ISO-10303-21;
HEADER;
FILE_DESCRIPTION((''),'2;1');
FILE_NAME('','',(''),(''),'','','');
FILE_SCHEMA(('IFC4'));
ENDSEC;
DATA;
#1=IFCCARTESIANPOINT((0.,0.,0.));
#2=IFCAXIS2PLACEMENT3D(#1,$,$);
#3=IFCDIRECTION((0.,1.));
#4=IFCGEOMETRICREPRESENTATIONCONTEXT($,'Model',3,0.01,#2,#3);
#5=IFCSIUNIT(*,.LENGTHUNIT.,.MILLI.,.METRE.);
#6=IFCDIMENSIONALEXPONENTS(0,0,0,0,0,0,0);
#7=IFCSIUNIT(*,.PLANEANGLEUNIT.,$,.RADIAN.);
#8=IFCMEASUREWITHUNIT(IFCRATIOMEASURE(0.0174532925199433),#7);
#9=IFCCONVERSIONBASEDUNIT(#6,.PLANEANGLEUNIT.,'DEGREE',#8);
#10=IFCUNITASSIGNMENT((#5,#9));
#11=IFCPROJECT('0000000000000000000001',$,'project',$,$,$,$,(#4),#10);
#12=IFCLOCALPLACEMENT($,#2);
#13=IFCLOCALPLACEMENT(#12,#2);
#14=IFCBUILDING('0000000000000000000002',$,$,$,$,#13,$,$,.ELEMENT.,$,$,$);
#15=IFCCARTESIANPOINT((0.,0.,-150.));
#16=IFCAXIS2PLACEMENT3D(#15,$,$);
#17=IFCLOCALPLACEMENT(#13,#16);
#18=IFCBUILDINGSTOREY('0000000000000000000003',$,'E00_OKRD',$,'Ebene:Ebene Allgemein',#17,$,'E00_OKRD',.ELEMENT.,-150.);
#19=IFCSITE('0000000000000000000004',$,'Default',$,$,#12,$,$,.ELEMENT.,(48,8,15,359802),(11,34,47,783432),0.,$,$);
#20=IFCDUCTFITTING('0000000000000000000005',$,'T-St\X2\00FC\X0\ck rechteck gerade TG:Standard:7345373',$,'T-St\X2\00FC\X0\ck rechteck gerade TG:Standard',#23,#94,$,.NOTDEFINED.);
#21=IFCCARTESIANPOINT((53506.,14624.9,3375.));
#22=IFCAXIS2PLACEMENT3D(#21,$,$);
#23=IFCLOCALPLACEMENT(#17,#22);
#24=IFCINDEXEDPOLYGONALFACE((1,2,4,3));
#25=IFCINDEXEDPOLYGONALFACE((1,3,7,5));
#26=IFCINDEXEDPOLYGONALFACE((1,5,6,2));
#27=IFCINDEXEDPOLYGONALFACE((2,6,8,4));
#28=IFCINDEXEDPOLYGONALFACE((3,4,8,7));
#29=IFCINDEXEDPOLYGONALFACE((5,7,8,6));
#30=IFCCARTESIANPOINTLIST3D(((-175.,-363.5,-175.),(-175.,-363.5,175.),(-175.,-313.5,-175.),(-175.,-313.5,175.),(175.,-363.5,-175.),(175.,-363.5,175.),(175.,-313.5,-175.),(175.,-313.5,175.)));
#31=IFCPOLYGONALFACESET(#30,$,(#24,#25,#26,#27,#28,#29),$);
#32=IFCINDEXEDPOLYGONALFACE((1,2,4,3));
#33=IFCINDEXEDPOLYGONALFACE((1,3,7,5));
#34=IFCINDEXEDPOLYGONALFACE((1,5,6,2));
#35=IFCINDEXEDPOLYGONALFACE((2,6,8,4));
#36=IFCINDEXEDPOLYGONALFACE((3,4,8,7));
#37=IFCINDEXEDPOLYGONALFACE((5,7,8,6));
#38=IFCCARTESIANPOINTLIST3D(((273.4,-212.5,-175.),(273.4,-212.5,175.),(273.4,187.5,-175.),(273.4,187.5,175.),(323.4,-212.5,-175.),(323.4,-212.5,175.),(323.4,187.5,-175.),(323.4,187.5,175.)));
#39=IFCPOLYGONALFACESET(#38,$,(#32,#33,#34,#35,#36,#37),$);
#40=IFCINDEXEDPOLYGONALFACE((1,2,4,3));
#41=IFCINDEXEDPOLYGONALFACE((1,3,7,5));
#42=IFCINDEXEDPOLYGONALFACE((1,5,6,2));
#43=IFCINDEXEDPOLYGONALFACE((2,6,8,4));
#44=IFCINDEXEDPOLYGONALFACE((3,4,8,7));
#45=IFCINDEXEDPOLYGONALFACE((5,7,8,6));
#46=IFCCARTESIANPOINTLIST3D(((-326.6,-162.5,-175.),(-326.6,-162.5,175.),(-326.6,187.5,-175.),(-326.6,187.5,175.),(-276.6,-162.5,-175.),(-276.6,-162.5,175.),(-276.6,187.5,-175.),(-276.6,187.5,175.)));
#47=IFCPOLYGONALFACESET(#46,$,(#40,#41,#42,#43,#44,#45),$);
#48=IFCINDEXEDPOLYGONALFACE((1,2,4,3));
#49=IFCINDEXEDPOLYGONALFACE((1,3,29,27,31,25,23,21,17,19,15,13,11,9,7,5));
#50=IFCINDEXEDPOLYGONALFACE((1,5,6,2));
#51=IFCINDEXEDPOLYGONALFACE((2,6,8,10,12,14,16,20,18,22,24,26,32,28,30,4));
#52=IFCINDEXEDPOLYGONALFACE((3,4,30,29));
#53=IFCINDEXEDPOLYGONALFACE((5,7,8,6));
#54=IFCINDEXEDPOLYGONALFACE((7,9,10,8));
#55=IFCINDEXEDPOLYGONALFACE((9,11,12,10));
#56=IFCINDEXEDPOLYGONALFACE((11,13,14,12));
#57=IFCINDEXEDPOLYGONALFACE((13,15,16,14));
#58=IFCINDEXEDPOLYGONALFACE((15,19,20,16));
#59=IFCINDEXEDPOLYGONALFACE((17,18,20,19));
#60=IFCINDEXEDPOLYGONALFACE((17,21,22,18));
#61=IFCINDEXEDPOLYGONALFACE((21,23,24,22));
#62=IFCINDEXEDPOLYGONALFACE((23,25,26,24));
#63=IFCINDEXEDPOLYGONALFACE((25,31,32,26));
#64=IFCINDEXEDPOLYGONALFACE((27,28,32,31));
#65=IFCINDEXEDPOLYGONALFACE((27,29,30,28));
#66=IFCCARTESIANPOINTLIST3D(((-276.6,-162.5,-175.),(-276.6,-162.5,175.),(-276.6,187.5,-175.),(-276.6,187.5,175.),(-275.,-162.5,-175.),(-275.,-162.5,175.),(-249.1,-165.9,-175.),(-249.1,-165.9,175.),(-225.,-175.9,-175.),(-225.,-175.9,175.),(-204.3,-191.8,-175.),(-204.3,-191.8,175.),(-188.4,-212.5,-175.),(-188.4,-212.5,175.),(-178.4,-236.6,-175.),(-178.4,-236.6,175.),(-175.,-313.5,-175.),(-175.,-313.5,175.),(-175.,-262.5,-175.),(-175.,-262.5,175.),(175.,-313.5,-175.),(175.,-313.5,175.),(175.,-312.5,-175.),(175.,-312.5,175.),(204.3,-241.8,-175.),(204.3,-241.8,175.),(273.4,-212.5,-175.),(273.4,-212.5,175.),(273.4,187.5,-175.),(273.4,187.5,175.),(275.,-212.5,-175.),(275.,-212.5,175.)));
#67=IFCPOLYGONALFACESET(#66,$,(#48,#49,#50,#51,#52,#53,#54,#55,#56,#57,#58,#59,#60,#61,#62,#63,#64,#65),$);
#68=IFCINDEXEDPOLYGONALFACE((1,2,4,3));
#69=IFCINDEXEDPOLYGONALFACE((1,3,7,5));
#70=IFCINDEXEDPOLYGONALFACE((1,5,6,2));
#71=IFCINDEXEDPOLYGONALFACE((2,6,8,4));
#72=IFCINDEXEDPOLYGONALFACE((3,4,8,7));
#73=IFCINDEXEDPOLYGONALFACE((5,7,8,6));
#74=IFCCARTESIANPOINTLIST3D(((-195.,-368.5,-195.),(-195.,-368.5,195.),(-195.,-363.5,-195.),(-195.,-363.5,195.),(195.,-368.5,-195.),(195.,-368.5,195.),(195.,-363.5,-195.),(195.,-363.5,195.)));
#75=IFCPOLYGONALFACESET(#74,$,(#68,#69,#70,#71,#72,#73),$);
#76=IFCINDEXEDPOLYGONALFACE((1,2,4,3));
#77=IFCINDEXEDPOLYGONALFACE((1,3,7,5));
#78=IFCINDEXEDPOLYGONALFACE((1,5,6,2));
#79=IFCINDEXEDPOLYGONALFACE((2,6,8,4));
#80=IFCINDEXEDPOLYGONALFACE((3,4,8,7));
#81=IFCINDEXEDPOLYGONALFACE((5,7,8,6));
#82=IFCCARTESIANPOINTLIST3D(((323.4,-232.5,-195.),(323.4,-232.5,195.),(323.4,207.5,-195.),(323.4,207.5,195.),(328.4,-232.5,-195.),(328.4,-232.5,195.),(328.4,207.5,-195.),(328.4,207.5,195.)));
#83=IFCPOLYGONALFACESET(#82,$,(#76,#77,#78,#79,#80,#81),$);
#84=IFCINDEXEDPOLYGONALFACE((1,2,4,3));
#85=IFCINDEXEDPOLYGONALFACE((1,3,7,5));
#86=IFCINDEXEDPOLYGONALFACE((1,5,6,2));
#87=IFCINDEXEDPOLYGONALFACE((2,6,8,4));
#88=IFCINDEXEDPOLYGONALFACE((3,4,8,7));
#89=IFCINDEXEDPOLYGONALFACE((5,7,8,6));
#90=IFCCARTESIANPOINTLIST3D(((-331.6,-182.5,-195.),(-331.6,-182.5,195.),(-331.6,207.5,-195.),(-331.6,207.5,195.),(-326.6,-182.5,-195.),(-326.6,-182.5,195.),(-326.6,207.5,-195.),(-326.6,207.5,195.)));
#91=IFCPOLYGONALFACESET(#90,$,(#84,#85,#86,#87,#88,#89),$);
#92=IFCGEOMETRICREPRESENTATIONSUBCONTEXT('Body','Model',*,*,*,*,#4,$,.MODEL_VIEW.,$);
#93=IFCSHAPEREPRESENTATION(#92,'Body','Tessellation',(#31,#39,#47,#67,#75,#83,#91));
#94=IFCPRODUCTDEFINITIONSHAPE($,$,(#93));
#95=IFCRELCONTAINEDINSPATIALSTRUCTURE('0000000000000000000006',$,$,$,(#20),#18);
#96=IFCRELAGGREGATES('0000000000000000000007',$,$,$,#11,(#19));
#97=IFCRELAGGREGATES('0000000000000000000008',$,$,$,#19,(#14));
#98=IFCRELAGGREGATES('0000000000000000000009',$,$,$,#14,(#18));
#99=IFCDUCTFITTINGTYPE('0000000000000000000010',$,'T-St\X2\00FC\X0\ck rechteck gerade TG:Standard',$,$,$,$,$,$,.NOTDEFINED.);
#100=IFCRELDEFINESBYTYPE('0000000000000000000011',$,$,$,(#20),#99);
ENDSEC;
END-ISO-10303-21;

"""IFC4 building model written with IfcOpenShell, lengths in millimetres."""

from ifc_helpers import new_model, entity, si_unit, converted_unit, direction, frame, frame_2d, origin, origin_2d_with_axis, place, context, subcontext, project, spatial, polyline, circle_curve, parameter, trimmed, segment, composite_curve, rectangle, outline, extrude, source, transform, mapped, type_object, type_shapes, element, save


model = new_model("IFC4")

# Units and contexts
model_context = context("Model", 3, precision=0.01, world=origin(), true_north=direction((0.0, 1.0)))
body_context = subcontext(model_context, "Body", "Model", "MODEL_VIEW")
ifc_project = project(units=[si_unit("LENGTHUNIT", "METRE", prefix="MILLI"), converted_unit("PLANEANGLEUNIT", "DEGREE", entity("IfcRatioMeasure", 0.0174532925199433), si_unit("PLANEANGLEUNIT", "RADIAN"), dimensions=[0, 0, 0, 0, 0, 0, 0])], contexts=[model_context])

# Site, building, storey
site_placement = place(None, origin())
site = spatial("IfcSite", under=ifc_project, at=site_placement, Name="Default", CompositionType="ELEMENT", RefLatitude=(48, 8, 15, 359802), RefLongitude=(11, 34, 47, 783432), RefElevation=0.0)
building_placement = place(site_placement, origin())
building = spatial("IfcBuilding", under=site, at=building_placement, CompositionType="ELEMENT")
storey_placement = place(building_placement, frame((0.0, 0.0, -150.0)))
storey = spatial("IfcBuildingStorey", under=building, at=storey_placement, Name="E00_OKRD", ObjectType="Ebene:Ebene Allgemein", LongName="E00_OKRD", CompositionType="ELEMENT", Elevation=-150.0)

# Duct fitting
duct_fitting_type_1 = type_object("IfcDuctFittingType", Name="T-Stück rechteck gerade TG:Standard", PredefinedType="NOTDEFINED")
shared_shape_1 = source(origin(), body_context, "Body", "SweptSolid", [
    extrude(rectangle(XDim=50.0, YDim=350.0, at=origin_2d_with_axis()), frame((0.0, -338.5, -175.0), z_axis=(0.0, 0.0, 1.0), x_axis=(0.0, -1.0, 0.0)), (0.0, 0.0, 1.0), 350.0),
    extrude(rectangle(XDim=50.0, YDim=400.0, at=origin_2d_with_axis()), frame((298.4, -12.5, -175.0), z_axis=(0.0, 0.0, 1.0), x_axis=(-1.0, 0.0, 0.0)), (0.0, 0.0, 1.0), 350.0),
    extrude(rectangle(XDim=50.0, YDim=350.0, at=origin_2d_with_axis()), frame((-301.6, 12.5, -175.0)), (0.0, 0.0, 1.0), 350.0),
    extrude(outline(composite_curve([segment(trimmed(circle_curve(frame_2d((-275.6, -154.8), x_axis=(-1.0, 0.0)), 100.0), [parameter(180.0)], [parameter(270.0)], True, "PARAMETER"), False, "CONTINUOUS"), segment(polyline([(-175.6, -154.8), (-175.6, -155.8)]), True, "CONTINUOUS"), segment(polyline([(-175.6, -155.8), (174.4, -155.8)]), True, "CONTINUOUS"), segment(polyline([(174.4, -155.8), (174.4, -104.8)]), True, "CONTINUOUS"), segment(trimmed(circle_curve(frame_2d((274.4, -104.8), x_axis=(-1.0, 0.0)), 100.0), [parameter(270.0)], [parameter(0.0)], True, "PARAMETER"), False, "CONTINUOUS"), segment(polyline([(274.4, -4.8), (276.0, -4.8)]), True, "CONTINUOUS"), segment(polyline([(276.0, -4.8), (276.0, 345.2)]), True, "CONTINUOUS"), segment(polyline([(276.0, 345.2), (-274.0, 345.2)]), True, "CONTINUOUS"), segment(polyline([(-274.0, 345.2), (-274.0, -54.8)]), True, "CONTINUOUS"), segment(polyline([(-274.0, -54.8), (-275.6, -54.8)]), True, "CONTINUOUS")], self_intersect=False)), frame((-0.6, -157.7, -175.0), z_axis=(0.0, 0.0, -1.0), x_axis=(-1.0, 0.0, 0.0)), (0.0, 0.0, -1.0), 350.0),
    extrude(rectangle(XDim=5.0, YDim=390.0, at=origin_2d_with_axis()), frame((0.0, -366.0, -195.0), z_axis=(0.0, 0.0, 1.0), x_axis=(0.0, 1.0, 0.0)), (0.0, 0.0, 1.0), 390.0),
    extrude(rectangle(XDim=5.0, YDim=440.0, at=origin_2d_with_axis()), frame((325.9, -12.5, -195.0), z_axis=(0.0, 0.0, 1.0), x_axis=(-1.0, 0.0, 0.0)), (0.0, 0.0, 1.0), 390.0),
    extrude(rectangle(XDim=5.0, YDim=390.0, at=origin_2d_with_axis()), frame((-329.1, 12.5, -195.0), z_axis=(0.0, 0.0, 1.0), x_axis=(-1.0, 0.0, 0.0)), (0.0, 0.0, 1.0), 390.0),
])
type_shapes(duct_fitting_type_1, [shared_shape_1])
duct_fitting_1_placement = place(storey_placement, frame((53506.0, 14624.9, 3375.0)))
element("IfcDuctFitting", 1, at=duct_fitting_1_placement, inside=storey, type_object=duct_fitting_type_1, Name="T-Stück rechteck gerade TG:Standard:7345373", ObjectType="T-Stück rechteck gerade TG:Standard", PredefinedType="NOTDEFINED", context=body_context, shape_type="MappedRepresentation", body=[
    mapped(shared_shape_1, transform((0.0, 0.0, 0.0), scale=1.0)),
])

save(model, "model.ifc")
